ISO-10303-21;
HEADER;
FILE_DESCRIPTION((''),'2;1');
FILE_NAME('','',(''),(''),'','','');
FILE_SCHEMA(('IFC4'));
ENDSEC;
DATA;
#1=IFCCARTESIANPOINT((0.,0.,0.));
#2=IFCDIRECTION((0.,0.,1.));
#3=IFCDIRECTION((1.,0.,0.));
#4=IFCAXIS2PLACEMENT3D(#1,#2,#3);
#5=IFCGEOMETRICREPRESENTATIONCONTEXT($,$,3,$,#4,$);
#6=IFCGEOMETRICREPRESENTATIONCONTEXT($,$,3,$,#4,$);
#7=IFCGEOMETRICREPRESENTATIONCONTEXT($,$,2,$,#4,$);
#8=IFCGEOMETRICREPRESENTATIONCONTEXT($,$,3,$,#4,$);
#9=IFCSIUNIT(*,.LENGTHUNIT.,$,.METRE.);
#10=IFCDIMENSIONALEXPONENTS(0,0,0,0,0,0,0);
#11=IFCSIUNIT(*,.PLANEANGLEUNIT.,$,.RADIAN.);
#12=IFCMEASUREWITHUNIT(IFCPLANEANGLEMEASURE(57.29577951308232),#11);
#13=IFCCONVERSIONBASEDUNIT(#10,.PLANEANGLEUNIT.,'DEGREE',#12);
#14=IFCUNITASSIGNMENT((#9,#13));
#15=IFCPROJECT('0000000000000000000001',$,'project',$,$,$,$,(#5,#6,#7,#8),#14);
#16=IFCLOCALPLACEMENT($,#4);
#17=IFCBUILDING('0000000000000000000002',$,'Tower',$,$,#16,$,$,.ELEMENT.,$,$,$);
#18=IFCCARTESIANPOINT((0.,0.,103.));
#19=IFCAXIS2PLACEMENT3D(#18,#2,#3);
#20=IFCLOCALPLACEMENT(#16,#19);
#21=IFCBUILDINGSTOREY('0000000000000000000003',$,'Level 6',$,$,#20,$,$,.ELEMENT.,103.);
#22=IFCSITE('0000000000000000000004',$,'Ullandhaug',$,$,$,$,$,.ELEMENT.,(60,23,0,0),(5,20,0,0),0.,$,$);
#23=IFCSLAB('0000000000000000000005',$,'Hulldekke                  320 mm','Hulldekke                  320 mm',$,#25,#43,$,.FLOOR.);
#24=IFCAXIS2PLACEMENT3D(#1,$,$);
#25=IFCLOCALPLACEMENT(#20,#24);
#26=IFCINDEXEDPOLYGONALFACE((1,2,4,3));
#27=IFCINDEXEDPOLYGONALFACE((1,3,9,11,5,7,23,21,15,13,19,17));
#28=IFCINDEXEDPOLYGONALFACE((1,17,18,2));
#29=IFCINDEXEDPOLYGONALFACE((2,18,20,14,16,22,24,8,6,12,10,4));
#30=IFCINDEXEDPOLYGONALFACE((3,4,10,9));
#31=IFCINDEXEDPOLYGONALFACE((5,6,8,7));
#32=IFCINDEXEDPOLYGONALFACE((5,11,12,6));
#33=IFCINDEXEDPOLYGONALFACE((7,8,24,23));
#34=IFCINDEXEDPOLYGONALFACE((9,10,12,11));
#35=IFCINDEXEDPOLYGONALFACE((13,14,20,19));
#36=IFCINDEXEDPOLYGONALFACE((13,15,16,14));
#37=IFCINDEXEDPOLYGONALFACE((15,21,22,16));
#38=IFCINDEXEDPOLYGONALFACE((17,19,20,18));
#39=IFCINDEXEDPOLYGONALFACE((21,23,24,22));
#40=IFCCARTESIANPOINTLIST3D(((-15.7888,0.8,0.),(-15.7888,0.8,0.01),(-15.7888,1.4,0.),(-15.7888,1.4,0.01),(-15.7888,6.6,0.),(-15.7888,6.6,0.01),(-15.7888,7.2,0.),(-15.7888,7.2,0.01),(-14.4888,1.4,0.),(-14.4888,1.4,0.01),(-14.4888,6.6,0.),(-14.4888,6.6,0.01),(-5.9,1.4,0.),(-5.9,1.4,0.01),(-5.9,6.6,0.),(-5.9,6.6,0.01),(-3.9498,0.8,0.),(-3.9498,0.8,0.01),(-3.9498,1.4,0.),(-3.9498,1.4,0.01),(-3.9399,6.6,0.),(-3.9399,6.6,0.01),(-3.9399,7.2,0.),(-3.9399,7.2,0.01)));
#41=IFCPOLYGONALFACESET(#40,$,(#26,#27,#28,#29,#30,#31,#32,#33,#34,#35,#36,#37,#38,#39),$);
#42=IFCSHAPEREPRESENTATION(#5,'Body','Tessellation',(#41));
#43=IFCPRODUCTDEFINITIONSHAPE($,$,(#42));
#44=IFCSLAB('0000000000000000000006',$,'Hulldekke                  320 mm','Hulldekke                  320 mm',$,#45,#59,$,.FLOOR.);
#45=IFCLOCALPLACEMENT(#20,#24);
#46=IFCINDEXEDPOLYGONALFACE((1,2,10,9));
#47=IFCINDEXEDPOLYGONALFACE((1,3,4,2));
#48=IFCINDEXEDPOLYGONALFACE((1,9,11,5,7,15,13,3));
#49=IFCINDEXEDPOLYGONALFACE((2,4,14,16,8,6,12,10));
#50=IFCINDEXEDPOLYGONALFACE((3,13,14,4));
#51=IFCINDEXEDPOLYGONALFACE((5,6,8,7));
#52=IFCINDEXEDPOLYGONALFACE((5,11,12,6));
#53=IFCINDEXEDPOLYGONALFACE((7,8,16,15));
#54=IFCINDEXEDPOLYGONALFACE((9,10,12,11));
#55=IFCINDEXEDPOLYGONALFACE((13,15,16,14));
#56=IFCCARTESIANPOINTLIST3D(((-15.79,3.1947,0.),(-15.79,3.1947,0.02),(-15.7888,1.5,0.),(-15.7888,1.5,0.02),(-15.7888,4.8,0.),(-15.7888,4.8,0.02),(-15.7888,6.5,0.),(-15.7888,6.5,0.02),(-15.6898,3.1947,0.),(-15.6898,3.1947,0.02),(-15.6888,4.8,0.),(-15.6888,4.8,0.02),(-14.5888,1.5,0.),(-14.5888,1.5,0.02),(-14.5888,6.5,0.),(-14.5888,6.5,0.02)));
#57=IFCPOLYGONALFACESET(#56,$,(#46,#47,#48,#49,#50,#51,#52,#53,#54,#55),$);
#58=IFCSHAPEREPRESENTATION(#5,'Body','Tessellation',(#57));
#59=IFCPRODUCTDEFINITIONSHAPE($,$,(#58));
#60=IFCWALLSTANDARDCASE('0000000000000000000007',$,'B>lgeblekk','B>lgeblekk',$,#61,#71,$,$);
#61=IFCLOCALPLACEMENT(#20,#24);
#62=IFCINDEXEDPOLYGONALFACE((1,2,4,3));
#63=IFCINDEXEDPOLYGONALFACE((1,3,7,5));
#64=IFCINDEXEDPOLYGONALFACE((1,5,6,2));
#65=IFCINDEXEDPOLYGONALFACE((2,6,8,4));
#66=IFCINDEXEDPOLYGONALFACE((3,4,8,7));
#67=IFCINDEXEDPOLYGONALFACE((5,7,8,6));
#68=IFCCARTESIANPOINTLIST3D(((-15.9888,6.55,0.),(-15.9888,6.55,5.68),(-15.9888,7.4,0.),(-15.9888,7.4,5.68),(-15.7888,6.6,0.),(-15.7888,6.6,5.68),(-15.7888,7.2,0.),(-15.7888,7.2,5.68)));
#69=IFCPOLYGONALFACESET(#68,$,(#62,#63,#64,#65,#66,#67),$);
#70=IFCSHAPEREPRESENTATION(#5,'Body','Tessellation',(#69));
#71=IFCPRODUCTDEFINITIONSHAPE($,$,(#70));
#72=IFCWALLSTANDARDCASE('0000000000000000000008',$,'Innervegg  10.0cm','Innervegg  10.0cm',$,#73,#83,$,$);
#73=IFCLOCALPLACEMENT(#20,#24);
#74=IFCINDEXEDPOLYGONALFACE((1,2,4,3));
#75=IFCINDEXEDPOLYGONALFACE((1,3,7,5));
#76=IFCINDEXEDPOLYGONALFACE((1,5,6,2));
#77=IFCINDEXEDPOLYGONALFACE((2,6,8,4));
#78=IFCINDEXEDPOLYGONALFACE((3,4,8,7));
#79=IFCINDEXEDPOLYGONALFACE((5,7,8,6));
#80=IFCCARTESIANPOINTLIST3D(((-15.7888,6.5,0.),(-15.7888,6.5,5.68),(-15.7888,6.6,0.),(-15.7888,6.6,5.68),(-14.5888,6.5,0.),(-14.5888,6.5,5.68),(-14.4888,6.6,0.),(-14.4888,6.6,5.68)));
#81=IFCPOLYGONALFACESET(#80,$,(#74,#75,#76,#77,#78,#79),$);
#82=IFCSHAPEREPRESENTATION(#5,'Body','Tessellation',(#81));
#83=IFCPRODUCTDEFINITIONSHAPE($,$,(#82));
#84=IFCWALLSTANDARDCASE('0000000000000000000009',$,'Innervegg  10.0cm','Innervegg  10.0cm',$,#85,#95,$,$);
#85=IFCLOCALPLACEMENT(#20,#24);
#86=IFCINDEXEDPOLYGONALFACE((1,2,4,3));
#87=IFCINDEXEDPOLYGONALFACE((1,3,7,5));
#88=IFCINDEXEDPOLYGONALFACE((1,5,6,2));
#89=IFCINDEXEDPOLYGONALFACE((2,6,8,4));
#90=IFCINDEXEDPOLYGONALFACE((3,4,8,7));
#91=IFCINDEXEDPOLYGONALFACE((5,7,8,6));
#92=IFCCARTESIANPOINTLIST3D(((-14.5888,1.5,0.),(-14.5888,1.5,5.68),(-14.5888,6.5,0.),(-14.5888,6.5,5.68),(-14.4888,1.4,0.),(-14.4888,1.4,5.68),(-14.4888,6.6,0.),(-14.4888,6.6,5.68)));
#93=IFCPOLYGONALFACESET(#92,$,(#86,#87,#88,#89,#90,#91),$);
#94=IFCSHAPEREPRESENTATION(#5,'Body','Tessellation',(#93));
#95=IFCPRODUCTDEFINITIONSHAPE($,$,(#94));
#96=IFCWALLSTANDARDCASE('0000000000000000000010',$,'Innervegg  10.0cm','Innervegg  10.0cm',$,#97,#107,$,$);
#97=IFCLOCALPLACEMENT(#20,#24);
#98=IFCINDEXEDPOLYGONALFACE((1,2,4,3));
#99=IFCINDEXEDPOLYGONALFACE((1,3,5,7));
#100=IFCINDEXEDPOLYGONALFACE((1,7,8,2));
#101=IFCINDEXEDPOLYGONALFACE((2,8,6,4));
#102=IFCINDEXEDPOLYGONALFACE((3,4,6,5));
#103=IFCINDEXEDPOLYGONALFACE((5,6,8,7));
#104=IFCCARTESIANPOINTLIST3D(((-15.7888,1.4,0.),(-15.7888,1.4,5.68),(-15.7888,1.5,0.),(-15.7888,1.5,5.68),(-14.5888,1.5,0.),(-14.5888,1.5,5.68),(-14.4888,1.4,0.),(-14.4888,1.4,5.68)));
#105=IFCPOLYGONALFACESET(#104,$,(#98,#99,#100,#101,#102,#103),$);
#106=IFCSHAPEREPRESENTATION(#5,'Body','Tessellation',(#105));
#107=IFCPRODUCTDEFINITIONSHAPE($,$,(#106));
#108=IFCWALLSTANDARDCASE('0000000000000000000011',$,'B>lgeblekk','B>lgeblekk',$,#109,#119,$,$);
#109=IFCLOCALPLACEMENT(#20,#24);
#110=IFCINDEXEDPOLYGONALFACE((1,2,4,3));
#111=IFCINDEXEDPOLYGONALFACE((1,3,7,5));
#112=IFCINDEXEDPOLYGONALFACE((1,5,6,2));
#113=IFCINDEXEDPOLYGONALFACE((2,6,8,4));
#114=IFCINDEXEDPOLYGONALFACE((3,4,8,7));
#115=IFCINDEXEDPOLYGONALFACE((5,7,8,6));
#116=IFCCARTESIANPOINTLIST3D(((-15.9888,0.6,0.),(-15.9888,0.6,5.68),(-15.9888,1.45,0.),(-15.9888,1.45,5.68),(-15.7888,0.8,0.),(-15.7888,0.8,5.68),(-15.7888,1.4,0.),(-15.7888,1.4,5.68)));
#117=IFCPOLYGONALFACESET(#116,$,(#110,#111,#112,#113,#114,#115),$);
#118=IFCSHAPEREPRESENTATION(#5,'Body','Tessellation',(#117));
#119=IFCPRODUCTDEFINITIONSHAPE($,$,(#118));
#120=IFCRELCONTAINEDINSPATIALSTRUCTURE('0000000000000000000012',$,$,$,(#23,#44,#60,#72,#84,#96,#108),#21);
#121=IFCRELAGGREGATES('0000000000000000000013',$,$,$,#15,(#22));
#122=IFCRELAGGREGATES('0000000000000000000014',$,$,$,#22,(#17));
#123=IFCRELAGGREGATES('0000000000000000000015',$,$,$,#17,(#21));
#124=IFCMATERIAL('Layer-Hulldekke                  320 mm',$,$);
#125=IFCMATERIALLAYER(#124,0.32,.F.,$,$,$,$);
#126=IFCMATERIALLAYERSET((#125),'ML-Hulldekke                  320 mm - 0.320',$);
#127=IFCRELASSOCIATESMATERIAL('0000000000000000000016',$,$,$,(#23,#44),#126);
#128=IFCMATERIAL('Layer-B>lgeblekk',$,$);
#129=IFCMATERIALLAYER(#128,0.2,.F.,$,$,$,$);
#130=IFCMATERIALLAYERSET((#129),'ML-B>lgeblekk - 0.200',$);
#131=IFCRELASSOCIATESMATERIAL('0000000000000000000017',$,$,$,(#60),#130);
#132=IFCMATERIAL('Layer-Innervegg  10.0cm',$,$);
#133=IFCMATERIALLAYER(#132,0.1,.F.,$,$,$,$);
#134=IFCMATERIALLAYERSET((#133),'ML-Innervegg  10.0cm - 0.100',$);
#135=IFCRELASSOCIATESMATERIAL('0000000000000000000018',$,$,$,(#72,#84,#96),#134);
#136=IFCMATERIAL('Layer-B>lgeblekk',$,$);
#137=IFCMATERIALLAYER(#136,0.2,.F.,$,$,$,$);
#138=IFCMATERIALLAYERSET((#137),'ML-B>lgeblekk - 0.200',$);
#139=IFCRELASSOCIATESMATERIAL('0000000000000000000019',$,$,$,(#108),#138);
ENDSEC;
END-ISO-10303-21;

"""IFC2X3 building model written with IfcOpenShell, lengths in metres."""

from ifc_helpers import new_model, entity, si_unit, converted_unit, frame, origin_with_axes, place, context, project, spatial, polyline, outline, extrude, material, layer, layer_set, layer_usage, element, save


model = new_model("IFC2X3")

# Units and contexts
context_of_model_1 = context(None, 3, world=origin_with_axes())
context_of_model_2 = context(None, 3, world=origin_with_axes())
context_of_model_3 = context(None, 2, world=origin_with_axes())
context_of_model_4 = context(None, 3, world=origin_with_axes())
ifc_project = project(units=[si_unit("LENGTHUNIT", "METRE"), converted_unit("PLANEANGLEUNIT", "DEGREE", entity("IfcPlaneAngleMeasure", 57.29577951308232), si_unit("PLANEANGLEUNIT", "RADIAN"), dimensions=[0, 0, 0, 0, 0, 0, 0])], contexts=[context_of_model_1, context_of_model_2, context_of_model_3, context_of_model_4])

# Site, building, storey
site = spatial("IfcSite", under=ifc_project, Name="Ullandhaug", CompositionType="ELEMENT", RefLatitude=(60, 23, 0, 0), RefLongitude=(5, 20, 0, 0), RefElevation=0.0)
building_placement = place(None, origin_with_axes())
building = spatial("IfcBuilding", under=site, at=building_placement, Name="Tower", CompositionType="ELEMENT")
storey_placement = place(building_placement, frame((0.0, 0.0, 103.0), z_axis=(0.0, 0.0, 1.0), x_axis=(1.0, 0.0, 0.0)))
storey = spatial("IfcBuildingStorey", under=building, at=storey_placement, Name="Level 6", CompositionType="ELEMENT", Elevation=103.0)

# Slabs
ifc_material_1 = material(Name="Layer-Hulldekke                  320 mm")
ifc_layer_1 = layer(ifc_material_1, 0.32, ventilated=False)
ifc_layer_set_1 = layer_set([ifc_layer_1], Name="ML-Hulldekke                  320 mm - 0.320")
ifc_layer_usage_1 = layer_usage(ifc_layer_set_1, "AXIS2", "POSITIVE", 0.0)
slab_1_placement = place(storey_placement, frame((-3.9399, 6.6, 0.0), z_axis=(0.0, 0.0, 1.0), x_axis=(1.0, 0.0, 0.0)))
element("IfcSlab", 1, at=slab_1_placement, inside=storey, material=ifc_layer_usage_1, Name="Hulldekke                  320 mm", Description="Hulldekke                  320 mm", PredefinedType="FLOOR", context=context_of_model_1, shape_type="SweptSolid", body=[
    extrude(outline(polyline([(0.0, 0.0), (0.6, 0.0), (0.6, 11.8489), (0.0, 11.8489), (0.0, 10.5489), (-5.2, 10.5489), (-5.2, 11.8489), (-5.8, 11.8489), (-5.8, 0.0099), (-5.2, 0.0099), (-5.2, 1.9601), (0.0, 1.9601), (0.0, 0.0)])), frame((0.0, 0.0, 0.0), z_axis=(0.0, 0.0, 1.0), x_axis=(0.0, 1.0, 0.0)), (0.0, 0.0, 1.0), 0.01),
])
slab_2_placement = place(storey_placement, frame((-15.7888, 6.5, 0.0), z_axis=(0.0, 0.0, 1.0), x_axis=(1.0, 0.0, 0.0)))
element("IfcSlab", 2, at=slab_2_placement, inside=storey, material=ifc_layer_usage_1, Name="Hulldekke                  320 mm", Description="Hulldekke                  320 mm", PredefinedType="FLOOR", context=context_of_model_1, shape_type="SweptSolid", body=[
    extrude(outline(polyline([(0.0, 0.0), (1.7, 0.0), (1.7, 0.1), (3.3053, 0.099), (3.3053, -0.0011), (5.0, 0.0), (5.0, 1.2), (0.0, 1.2), (0.0, 0.0)])), frame((0.0, 0.0, 0.0), z_axis=(0.0, 0.0, 1.0), x_axis=(0.0, -1.0, 0.0)), (0.0, 0.0, 1.0), 0.02),
])

# Walls
ifc_material_2 = material(Name="Layer-B>lgeblekk")
ifc_layer_2 = layer(ifc_material_2, 0.2, ventilated=False)
ifc_layer_set_2 = layer_set([ifc_layer_2], Name="ML-B>lgeblekk - 0.200")
ifc_layer_usage_2 = layer_usage(ifc_layer_set_2, "AXIS2", "POSITIVE", 0.0)
wall_1_placement = place(storey_placement, frame((-15.9888, 7.4, 0.0), z_axis=(0.0, 0.0, 1.0), x_axis=(0.0, -1.0, 0.0)))
element("IfcWallStandardCase", 3, at=wall_1_placement, inside=storey, material=ifc_layer_usage_2, Name="B>lgeblekk", Description="B>lgeblekk", context=context_of_model_1, shape_type="SweptSolid", body=[
    extrude(outline(polyline([(0.0, 0.0), (0.85, 0.0), (0.8, 0.2), (0.2, 0.2), (0.0, 0.0)])), frame((0.0, 0.0, 0.0), z_axis=(0.0, 0.0, 1.0), x_axis=(1.0, 0.0, 0.0)), (0.0, 0.0, 1.0), 5.68),
])
ifc_material_3 = material(Name="Layer-Innervegg  10.0cm")
ifc_layer_3 = layer(ifc_material_3, 0.1, ventilated=False)
ifc_layer_set_3 = layer_set([ifc_layer_3], Name="ML-Innervegg  10.0cm - 0.100")
ifc_layer_usage_3 = layer_usage(ifc_layer_set_3, "AXIS2", "POSITIVE", 0.0)
wall_2_placement = place(storey_placement, frame((-15.7888, 6.5, 0.0), z_axis=(0.0, 0.0, 1.0), x_axis=(1.0, 0.0, 0.0)))
element("IfcWallStandardCase", 4, at=wall_2_placement, inside=storey, material=ifc_layer_usage_3, Name="Innervegg  10.0cm", Description="Innervegg  10.0cm", context=context_of_model_1, shape_type="SweptSolid", body=[
    extrude(outline(polyline([(0.0, 0.0), (1.2, 0.0), (1.3, 0.1), (0.0, 0.1), (0.0, 0.0)])), origin_with_axes(), (0.0, 0.0, 1.0), 5.68),
])
wall_3_placement = place(storey_placement, frame((-14.5888, 6.5, 0.0), z_axis=(0.0, 0.0, 1.0), x_axis=(0.0, -1.0, 0.0)))
element("IfcWallStandardCase", 5, at=wall_3_placement, inside=storey, material=ifc_layer_usage_3, Name="Innervegg  10.0cm", Description="Innervegg  10.0cm", context=context_of_model_1, shape_type="SweptSolid", body=[
    extrude(outline(polyline([(0.0, 0.0), (5.0, 0.0), (5.1, 0.1), (-0.1, 0.1), (0.0, 0.0)])), frame((0.0, 0.0, 0.0), z_axis=(0.0, 0.0, 1.0), x_axis=(1.0, 0.0, 0.0)), (0.0, 0.0, 1.0), 5.68),
])
wall_4_placement = place(storey_placement, frame((-14.5888, 1.5, 0.0), z_axis=(0.0, 0.0, 1.0), x_axis=(-1.0, 0.0, 0.0)))
element("IfcWallStandardCase", 6, at=wall_4_placement, inside=storey, material=ifc_layer_usage_3, Name="Innervegg  10.0cm", Description="Innervegg  10.0cm", context=context_of_model_1, shape_type="SweptSolid", body=[
    extrude(outline(polyline([(0.0, 0.0), (1.2, 0.0), (1.2, 0.1), (-0.1, 0.1), (0.0, 0.0)])), frame((0.0, 0.0, 0.0), z_axis=(0.0, 0.0, 1.0), x_axis=(1.0, 0.0, 0.0)), (0.0, 0.0, 1.0), 5.68),
])
ifc_material_4 = material(Name="Layer-B>lgeblekk")
ifc_layer_4 = layer(ifc_material_4, 0.2, ventilated=False)
ifc_layer_set_4 = layer_set([ifc_layer_4], Name="ML-B>lgeblekk - 0.200")
ifc_layer_usage_4 = layer_usage(ifc_layer_set_4, "AXIS2", "POSITIVE", 0.0)
wall_5_placement = place(storey_placement, frame((-15.9888, 1.45, 0.0), z_axis=(0.0, 0.0, 1.0), x_axis=(0.0, -1.0, 0.0)))
element("IfcWallStandardCase", 7, at=wall_5_placement, inside=storey, material=ifc_layer_usage_4, Name="B>lgeblekk", Description="B>lgeblekk", context=context_of_model_1, shape_type="SweptSolid", body=[
    extrude(outline(polyline([(0.0, 0.0), (0.85, 0.0), (0.65, 0.2), (0.05, 0.2), (0.0, 0.0)])), frame((0.0, 0.0, 0.0), z_axis=(0.0, 0.0, 1.0), x_axis=(1.0, 0.0, 0.0)), (0.0, 0.0, 1.0), 5.68),
])

save(model, "model.ifc")
